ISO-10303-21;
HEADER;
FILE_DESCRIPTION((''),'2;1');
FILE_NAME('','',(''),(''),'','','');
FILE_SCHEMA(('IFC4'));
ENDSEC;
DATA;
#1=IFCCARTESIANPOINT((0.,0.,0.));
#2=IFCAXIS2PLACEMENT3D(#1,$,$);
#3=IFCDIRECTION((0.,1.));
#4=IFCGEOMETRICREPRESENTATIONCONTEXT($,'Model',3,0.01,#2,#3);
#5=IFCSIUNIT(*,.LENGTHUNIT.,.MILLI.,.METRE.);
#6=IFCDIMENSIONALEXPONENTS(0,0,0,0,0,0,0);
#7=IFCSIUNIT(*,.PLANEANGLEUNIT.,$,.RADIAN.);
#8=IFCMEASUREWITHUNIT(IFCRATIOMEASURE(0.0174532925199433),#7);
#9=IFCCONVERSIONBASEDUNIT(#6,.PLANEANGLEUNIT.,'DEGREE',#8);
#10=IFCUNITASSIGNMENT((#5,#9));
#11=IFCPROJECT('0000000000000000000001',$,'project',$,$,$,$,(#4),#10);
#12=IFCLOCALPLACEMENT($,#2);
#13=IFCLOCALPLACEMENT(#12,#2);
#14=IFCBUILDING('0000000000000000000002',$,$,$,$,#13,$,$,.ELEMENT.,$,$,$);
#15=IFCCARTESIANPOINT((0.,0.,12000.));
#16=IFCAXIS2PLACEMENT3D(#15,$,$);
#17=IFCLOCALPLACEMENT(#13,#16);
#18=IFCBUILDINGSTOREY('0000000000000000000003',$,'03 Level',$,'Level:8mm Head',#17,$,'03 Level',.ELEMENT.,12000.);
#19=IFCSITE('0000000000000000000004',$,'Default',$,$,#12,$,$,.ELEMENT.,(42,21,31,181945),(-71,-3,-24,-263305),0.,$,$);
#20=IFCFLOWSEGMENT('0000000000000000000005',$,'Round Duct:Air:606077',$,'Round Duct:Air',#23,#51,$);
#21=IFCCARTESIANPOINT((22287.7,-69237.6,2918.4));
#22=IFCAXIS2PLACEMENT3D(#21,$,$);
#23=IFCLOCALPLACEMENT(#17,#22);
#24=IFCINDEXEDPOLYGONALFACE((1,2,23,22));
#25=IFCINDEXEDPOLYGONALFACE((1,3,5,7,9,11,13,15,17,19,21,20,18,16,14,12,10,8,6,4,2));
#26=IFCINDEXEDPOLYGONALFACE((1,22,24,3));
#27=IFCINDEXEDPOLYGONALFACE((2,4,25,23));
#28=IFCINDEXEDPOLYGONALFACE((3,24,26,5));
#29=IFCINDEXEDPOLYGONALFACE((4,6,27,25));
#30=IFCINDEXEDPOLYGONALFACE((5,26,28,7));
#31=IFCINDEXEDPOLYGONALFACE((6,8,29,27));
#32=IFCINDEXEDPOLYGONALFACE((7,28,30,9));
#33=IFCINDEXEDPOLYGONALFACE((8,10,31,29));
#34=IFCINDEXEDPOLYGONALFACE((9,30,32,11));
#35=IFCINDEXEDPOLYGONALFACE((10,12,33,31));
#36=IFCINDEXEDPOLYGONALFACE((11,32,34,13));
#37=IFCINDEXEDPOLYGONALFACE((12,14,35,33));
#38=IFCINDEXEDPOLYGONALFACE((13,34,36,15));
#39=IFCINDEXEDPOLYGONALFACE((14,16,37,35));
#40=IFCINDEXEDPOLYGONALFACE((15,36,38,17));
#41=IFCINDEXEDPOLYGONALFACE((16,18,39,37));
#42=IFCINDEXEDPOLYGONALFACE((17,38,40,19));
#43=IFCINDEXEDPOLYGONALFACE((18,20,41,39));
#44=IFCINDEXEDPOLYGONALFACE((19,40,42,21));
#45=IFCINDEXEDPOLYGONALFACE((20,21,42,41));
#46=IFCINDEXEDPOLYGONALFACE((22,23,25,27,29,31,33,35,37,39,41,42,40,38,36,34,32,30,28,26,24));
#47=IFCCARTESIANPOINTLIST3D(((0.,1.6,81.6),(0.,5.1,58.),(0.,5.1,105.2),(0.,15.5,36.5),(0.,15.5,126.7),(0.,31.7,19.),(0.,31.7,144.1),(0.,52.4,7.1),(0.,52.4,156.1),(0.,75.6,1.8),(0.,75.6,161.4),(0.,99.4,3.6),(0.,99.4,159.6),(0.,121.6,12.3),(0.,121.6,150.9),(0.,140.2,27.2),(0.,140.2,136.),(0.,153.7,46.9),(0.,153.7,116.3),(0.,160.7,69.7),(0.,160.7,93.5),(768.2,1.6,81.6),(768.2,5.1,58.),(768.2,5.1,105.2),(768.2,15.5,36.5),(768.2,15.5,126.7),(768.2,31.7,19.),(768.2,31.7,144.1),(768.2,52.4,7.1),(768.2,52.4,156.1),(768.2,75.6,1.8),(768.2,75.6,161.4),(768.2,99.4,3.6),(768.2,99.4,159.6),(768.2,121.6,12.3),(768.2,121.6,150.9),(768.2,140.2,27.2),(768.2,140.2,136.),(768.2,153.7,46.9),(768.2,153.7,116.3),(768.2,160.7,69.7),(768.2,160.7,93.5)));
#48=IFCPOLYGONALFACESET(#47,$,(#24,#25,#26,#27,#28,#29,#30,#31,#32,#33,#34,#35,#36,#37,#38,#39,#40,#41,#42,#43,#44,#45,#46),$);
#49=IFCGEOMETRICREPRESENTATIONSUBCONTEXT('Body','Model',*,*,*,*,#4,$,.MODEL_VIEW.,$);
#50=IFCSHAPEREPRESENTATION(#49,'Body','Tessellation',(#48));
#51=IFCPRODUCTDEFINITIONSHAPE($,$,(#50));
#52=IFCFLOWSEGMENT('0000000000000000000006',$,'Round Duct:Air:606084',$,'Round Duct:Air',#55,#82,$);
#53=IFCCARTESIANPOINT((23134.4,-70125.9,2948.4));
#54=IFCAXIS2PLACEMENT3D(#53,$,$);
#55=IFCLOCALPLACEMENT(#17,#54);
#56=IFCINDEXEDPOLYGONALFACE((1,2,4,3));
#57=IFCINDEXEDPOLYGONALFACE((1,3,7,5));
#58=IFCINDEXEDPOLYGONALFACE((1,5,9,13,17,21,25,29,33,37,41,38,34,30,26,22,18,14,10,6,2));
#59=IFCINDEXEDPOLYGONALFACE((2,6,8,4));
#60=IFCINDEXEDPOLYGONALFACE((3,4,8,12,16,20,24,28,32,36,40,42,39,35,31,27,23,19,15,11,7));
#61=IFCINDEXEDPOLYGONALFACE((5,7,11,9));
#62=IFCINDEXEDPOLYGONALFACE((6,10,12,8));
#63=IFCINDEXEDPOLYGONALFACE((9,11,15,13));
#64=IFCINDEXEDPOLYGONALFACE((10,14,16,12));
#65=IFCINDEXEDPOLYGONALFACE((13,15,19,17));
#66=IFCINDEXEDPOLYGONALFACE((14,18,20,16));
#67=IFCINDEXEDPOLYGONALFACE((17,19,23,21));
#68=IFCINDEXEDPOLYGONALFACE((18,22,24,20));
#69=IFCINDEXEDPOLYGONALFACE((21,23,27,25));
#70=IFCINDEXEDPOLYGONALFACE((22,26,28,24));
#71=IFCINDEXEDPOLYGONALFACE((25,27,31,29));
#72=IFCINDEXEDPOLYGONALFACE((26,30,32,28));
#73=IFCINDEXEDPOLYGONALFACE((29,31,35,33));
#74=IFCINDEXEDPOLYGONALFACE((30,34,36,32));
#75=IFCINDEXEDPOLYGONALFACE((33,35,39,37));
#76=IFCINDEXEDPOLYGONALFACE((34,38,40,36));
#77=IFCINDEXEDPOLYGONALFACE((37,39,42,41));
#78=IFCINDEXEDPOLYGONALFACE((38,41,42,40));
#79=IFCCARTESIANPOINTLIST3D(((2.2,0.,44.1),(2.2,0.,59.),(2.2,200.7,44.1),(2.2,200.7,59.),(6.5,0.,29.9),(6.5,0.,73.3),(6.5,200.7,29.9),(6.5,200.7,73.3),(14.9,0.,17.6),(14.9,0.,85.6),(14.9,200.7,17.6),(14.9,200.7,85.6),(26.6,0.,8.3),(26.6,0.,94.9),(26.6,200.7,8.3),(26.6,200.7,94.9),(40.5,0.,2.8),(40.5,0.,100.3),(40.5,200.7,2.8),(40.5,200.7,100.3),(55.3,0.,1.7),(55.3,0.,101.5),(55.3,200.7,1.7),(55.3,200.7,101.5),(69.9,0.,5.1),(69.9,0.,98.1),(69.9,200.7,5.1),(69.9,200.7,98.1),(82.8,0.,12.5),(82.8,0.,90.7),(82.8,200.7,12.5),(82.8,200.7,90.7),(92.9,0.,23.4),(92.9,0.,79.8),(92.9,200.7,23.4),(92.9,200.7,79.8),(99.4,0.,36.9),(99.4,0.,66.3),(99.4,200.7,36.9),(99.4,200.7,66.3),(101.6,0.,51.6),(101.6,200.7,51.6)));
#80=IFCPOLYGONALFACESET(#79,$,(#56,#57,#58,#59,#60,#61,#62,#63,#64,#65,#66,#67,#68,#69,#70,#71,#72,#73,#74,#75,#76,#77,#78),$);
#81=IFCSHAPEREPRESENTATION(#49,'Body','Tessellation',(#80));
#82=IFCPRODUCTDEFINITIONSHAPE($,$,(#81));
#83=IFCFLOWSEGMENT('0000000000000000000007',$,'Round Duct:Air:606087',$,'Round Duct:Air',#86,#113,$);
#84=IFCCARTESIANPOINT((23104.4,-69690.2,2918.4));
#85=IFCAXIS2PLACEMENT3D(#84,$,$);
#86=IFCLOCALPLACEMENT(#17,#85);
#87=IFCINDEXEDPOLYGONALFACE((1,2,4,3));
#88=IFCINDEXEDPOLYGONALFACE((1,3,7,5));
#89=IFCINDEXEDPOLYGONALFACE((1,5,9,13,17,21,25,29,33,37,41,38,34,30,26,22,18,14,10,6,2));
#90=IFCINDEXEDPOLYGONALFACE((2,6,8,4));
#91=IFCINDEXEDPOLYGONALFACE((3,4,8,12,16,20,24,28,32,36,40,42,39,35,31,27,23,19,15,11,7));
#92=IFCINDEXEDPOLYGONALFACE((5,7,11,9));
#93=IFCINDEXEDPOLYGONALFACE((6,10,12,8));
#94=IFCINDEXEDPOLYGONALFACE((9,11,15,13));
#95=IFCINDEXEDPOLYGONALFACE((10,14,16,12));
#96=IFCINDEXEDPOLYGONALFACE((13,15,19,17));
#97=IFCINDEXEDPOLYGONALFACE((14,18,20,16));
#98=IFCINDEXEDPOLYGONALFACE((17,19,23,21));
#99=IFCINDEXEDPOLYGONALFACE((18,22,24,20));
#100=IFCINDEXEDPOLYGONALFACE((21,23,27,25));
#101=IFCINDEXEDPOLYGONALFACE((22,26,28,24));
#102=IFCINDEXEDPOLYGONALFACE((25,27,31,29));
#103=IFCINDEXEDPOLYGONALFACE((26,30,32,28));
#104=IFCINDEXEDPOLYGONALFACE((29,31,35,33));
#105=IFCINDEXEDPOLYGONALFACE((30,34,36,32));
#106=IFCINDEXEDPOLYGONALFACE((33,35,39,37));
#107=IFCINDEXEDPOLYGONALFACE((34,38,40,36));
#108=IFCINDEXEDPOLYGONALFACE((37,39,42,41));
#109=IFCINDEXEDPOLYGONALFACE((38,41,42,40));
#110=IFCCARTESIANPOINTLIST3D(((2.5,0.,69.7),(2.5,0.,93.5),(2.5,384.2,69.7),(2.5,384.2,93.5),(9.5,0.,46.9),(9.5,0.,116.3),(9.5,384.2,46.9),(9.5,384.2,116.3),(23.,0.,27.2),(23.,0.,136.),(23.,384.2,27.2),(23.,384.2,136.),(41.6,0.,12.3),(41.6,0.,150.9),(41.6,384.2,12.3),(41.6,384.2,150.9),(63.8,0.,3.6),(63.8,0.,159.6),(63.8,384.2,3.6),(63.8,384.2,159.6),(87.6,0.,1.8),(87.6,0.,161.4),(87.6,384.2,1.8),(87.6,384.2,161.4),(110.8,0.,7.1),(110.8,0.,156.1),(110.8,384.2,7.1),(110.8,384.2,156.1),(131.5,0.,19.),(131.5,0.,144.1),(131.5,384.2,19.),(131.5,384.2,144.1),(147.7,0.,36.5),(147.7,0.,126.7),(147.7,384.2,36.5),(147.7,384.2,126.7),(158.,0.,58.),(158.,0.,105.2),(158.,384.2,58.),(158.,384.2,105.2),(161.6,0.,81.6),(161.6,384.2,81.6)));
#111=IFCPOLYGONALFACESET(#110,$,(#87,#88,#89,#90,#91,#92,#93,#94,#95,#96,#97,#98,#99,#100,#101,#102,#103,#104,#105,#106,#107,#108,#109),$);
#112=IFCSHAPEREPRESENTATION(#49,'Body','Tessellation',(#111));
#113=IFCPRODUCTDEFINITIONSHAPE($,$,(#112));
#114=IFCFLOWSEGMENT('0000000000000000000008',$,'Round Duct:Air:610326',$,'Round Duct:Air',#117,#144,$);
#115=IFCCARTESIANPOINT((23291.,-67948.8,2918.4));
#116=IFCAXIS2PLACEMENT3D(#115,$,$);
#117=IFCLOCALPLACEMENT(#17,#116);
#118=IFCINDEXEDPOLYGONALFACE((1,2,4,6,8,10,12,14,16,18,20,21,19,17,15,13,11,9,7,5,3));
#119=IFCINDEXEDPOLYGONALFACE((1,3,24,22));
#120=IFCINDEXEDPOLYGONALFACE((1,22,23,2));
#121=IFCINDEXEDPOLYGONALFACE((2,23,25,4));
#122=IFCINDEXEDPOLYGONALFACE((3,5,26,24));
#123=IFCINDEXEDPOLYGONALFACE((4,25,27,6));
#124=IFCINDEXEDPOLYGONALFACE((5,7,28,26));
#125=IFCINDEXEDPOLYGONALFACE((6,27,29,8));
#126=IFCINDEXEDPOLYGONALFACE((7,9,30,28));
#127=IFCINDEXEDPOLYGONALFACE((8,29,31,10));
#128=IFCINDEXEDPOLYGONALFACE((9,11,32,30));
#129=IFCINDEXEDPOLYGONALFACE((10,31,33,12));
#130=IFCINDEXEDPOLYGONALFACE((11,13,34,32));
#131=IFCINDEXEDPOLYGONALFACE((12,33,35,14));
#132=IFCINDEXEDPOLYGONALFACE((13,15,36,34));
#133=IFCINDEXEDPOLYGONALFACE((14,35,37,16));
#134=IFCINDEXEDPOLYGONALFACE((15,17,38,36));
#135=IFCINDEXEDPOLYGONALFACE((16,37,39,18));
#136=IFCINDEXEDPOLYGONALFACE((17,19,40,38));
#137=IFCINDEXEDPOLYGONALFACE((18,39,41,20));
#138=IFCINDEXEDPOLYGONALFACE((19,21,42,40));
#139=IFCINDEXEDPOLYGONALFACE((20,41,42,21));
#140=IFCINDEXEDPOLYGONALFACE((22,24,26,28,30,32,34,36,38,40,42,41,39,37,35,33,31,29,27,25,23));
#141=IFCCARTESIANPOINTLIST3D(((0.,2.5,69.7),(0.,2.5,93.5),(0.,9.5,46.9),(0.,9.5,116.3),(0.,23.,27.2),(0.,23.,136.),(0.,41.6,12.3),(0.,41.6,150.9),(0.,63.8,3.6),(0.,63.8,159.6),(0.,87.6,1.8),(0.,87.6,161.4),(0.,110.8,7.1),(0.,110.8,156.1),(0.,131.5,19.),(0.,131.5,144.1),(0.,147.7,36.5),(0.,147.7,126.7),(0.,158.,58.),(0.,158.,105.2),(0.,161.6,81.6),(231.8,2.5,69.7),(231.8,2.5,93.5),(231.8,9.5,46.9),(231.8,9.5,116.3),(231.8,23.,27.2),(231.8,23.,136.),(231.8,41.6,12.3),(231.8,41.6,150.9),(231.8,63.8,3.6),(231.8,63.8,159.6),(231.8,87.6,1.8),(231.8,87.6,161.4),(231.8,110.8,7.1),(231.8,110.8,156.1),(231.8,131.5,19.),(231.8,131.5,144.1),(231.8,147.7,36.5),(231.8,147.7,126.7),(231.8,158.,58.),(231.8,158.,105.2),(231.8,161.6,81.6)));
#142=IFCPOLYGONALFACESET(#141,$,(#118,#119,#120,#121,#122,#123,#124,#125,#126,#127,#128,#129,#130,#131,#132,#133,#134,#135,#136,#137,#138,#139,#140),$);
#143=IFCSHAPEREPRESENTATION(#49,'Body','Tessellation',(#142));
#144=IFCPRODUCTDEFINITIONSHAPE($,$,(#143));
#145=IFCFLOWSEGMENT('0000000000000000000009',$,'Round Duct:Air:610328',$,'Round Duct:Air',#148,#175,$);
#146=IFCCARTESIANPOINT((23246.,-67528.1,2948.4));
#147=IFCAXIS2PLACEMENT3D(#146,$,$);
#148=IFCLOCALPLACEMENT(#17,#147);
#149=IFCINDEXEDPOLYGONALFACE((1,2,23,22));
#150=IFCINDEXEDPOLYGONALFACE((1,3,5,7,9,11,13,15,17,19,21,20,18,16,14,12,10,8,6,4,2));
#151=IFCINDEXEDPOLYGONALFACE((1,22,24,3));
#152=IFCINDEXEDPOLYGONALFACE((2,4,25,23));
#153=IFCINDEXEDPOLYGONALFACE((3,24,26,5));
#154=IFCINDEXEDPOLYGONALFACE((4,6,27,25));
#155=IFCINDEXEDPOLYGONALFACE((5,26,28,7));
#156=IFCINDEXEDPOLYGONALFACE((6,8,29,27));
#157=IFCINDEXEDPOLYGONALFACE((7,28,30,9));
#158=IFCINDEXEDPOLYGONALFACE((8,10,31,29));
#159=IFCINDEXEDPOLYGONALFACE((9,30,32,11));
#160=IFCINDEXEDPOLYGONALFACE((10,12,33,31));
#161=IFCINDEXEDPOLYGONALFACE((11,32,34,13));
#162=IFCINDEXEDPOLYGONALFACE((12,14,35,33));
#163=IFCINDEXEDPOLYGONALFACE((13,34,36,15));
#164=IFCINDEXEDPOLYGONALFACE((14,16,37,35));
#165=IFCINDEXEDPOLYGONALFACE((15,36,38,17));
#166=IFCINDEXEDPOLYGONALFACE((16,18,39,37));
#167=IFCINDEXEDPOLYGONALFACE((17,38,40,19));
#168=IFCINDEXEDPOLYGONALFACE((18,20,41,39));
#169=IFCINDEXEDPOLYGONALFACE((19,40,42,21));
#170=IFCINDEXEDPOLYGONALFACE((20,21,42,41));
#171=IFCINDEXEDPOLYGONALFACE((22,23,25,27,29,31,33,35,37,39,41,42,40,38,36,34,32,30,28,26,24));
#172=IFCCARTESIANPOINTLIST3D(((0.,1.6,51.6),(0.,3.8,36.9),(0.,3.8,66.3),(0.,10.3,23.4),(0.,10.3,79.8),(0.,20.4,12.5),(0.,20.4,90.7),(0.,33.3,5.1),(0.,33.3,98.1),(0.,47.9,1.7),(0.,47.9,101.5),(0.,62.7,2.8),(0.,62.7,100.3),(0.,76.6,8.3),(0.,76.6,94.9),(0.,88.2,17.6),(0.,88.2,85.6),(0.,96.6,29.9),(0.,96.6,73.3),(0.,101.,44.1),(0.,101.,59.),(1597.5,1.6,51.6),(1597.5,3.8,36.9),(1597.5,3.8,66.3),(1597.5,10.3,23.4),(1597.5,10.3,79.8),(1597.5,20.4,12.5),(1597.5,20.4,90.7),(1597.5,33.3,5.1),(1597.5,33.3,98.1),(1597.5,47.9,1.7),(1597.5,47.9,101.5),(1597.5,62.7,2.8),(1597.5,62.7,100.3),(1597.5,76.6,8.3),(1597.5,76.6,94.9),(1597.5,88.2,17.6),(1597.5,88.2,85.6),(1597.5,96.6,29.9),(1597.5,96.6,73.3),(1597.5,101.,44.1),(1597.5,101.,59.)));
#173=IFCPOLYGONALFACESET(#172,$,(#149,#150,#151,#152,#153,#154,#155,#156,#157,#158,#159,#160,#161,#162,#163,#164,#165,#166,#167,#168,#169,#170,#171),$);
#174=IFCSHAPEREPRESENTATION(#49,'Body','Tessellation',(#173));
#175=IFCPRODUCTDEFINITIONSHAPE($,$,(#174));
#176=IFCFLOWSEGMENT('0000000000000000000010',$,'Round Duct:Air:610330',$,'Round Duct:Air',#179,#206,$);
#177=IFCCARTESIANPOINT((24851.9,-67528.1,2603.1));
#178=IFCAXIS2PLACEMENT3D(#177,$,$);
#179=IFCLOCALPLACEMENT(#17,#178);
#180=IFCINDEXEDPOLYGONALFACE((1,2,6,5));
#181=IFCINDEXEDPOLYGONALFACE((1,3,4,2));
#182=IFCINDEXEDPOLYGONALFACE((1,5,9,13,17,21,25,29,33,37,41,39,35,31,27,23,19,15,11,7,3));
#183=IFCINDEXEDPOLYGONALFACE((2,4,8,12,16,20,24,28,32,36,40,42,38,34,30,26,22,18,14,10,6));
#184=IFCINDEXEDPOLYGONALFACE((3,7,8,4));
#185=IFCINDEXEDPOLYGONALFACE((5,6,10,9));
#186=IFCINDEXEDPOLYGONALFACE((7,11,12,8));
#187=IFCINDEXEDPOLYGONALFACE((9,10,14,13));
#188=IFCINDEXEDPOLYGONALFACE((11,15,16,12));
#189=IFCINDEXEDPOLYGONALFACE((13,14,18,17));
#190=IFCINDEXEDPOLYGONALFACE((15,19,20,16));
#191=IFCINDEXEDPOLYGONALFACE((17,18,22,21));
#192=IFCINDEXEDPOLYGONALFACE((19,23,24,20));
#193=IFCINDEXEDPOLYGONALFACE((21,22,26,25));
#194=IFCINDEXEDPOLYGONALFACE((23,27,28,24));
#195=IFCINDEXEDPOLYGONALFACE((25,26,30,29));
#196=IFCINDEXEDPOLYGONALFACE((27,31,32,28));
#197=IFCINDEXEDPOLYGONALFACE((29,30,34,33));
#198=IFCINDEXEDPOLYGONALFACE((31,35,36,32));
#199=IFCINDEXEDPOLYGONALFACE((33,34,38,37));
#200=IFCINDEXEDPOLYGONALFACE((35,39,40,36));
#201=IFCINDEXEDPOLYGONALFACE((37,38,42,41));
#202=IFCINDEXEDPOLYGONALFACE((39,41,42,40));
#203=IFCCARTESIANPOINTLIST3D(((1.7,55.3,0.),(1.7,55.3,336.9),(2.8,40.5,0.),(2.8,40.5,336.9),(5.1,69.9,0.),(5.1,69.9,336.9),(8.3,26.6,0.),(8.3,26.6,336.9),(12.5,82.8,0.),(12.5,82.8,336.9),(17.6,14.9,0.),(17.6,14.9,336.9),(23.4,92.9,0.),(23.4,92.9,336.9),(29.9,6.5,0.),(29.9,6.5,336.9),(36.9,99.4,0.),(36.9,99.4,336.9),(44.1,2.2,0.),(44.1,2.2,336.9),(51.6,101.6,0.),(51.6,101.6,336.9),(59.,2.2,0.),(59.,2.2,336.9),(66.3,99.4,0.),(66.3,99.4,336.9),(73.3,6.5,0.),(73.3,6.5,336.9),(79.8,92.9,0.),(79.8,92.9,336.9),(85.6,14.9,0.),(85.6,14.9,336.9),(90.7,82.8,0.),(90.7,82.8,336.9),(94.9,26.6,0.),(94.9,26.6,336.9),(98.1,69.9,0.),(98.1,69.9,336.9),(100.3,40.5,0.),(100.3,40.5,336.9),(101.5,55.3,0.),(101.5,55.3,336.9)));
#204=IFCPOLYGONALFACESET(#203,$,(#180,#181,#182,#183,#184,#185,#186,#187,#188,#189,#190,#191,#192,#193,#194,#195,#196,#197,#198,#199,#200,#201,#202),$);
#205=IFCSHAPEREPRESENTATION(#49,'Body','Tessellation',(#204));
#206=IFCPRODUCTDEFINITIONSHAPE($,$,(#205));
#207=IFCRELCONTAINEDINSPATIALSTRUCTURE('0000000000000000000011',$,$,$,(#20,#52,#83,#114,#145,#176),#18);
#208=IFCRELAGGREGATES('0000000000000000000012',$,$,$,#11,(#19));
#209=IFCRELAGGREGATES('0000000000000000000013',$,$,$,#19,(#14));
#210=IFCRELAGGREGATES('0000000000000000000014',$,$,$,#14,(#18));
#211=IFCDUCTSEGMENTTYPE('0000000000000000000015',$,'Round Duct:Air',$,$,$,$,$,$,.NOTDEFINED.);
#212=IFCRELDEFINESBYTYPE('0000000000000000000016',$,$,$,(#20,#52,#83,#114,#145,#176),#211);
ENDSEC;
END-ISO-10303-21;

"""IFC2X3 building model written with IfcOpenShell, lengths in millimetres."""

from ifc_helpers import new_model, entity, si_unit, converted_unit, direction, frame, origin, origin_2d_with_axis, place, context, subcontext, project, spatial, circle, extrude, type_object, element, save


model = new_model("IFC2X3")

# Units and contexts
model_context = context("Model", 3, precision=0.01, world=origin(), true_north=direction((0.0, 1.0)))
body_context = subcontext(model_context, "Body", "Model", "MODEL_VIEW")
ifc_project = project(units=[si_unit("LENGTHUNIT", "METRE", prefix="MILLI"), converted_unit("PLANEANGLEUNIT", "DEGREE", entity("IfcRatioMeasure", 0.0174532925199433), si_unit("PLANEANGLEUNIT", "RADIAN"), dimensions=[0, 0, 0, 0, 0, 0, 0])], contexts=[model_context])

# Site, building, storey
site_placement = place(None, origin())
site = spatial("IfcSite", under=ifc_project, at=site_placement, Name="Default", CompositionType="ELEMENT", RefLatitude=(42, 21, 31, 181945), RefLongitude=(-71, -3, -24, -263305), RefElevation=0.0)
building_placement = place(site_placement, origin())
building = spatial("IfcBuilding", under=site, at=building_placement, CompositionType="ELEMENT")
storey_placement = place(building_placement, frame((0.0, 0.0, 12000.0)))
storey = spatial("IfcBuildingStorey", under=building, at=storey_placement, Name="03 Level", ObjectType="Level:8mm Head", LongName="03 Level", CompositionType="ELEMENT", Elevation=12000.0)

# Flow segments
duct_segment_type_1 = type_object("IfcDuctSegmentType", Name="Round Duct:Air", PredefinedType="NOTDEFINED")
flow_segment_1_placement = place(storey_placement, frame((22287.7, -69237.6, 2918.4)))
element("IfcFlowSegment", 1, at=flow_segment_1_placement, inside=storey, type_object=duct_segment_type_1, Name="Round Duct:Air:606077", ObjectType="Round Duct:Air", context=body_context, shape_type="SweptSolid", body=[
    extrude(circle(Radius=80.0, at=origin_2d_with_axis()), frame((0.0, 81.6, 81.6), z_axis=(1.0, 0.0, 0.0), x_axis=(0.0, -1.0, 0.0)), (0.0, 0.0, 1.0), 768.2),
])
flow_segment_2_placement = place(storey_placement, frame((23134.4, -70125.9, 2948.4)))
element("IfcFlowSegment", 2, at=flow_segment_2_placement, inside=storey, type_object=duct_segment_type_1, Name="Round Duct:Air:606084", ObjectType="Round Duct:Air", context=body_context, shape_type="SweptSolid", body=[
    extrude(circle(Radius=50.0, at=origin_2d_with_axis()), frame((51.6, 0.0, 51.6), z_axis=(0.0, 1.0, 0.0), x_axis=(1.0, 0.0, 0.0)), (0.0, 0.0, 1.0), 200.7),
])
flow_segment_3_placement = place(storey_placement, frame((23104.4, -69690.2, 2918.4)))
element("IfcFlowSegment", 3, at=flow_segment_3_placement, inside=storey, type_object=duct_segment_type_1, Name="Round Duct:Air:606087", ObjectType="Round Duct:Air", context=body_context, shape_type="SweptSolid", body=[
    extrude(circle(Radius=80.0, at=origin_2d_with_axis()), frame((81.6, 0.0, 81.6), z_axis=(0.0, 1.0, 0.0), x_axis=(1.0, 0.0, 0.0)), (0.0, 0.0, 1.0), 384.2),
])
flow_segment_4_placement = place(storey_placement, frame((23291.0, -67948.8, 2918.4)))
element("IfcFlowSegment", 4, at=flow_segment_4_placement, inside=storey, type_object=duct_segment_type_1, Name="Round Duct:Air:610326", ObjectType="Round Duct:Air", context=body_context, shape_type="SweptSolid", body=[
    extrude(circle(Radius=80.0, at=origin_2d_with_axis()), frame((0.0, 81.6, 81.6), z_axis=(1.0, 0.0, 0.0), x_axis=(0.0, 1.0, 0.0)), (0.0, 0.0, 1.0), 231.8),
])
flow_segment_5_placement = place(storey_placement, frame((23246.0, -67528.1, 2948.4)))
element("IfcFlowSegment", 5, at=flow_segment_5_placement, inside=storey, type_object=duct_segment_type_1, Name="Round Duct:Air:610328", ObjectType="Round Duct:Air", context=body_context, shape_type="SweptSolid", body=[
    extrude(circle(Radius=50.0, at=origin_2d_with_axis()), frame((0.0, 51.6, 51.6), z_axis=(1.0, 0.0, 0.0), x_axis=(0.0, -1.0, 0.0)), (0.0, 0.0, 1.0), 1597.5),
])
flow_segment_6_placement = place(storey_placement, frame((24851.9, -67528.1, 2603.1)))
element("IfcFlowSegment", 6, at=flow_segment_6_placement, inside=storey, type_object=duct_segment_type_1, Name="Round Duct:Air:610330", ObjectType="Round Duct:Air", context=body_context, shape_type="SweptSolid", body=[
    extrude(circle(Radius=50.0, at=origin_2d_with_axis()), frame((51.6, 51.6, 0.0), z_axis=(0.0, 0.0, 1.0), x_axis=(0.0, 1.0, 0.0)), (0.0, 0.0, 1.0), 336.9),
])

save(model, "model.ifc")
